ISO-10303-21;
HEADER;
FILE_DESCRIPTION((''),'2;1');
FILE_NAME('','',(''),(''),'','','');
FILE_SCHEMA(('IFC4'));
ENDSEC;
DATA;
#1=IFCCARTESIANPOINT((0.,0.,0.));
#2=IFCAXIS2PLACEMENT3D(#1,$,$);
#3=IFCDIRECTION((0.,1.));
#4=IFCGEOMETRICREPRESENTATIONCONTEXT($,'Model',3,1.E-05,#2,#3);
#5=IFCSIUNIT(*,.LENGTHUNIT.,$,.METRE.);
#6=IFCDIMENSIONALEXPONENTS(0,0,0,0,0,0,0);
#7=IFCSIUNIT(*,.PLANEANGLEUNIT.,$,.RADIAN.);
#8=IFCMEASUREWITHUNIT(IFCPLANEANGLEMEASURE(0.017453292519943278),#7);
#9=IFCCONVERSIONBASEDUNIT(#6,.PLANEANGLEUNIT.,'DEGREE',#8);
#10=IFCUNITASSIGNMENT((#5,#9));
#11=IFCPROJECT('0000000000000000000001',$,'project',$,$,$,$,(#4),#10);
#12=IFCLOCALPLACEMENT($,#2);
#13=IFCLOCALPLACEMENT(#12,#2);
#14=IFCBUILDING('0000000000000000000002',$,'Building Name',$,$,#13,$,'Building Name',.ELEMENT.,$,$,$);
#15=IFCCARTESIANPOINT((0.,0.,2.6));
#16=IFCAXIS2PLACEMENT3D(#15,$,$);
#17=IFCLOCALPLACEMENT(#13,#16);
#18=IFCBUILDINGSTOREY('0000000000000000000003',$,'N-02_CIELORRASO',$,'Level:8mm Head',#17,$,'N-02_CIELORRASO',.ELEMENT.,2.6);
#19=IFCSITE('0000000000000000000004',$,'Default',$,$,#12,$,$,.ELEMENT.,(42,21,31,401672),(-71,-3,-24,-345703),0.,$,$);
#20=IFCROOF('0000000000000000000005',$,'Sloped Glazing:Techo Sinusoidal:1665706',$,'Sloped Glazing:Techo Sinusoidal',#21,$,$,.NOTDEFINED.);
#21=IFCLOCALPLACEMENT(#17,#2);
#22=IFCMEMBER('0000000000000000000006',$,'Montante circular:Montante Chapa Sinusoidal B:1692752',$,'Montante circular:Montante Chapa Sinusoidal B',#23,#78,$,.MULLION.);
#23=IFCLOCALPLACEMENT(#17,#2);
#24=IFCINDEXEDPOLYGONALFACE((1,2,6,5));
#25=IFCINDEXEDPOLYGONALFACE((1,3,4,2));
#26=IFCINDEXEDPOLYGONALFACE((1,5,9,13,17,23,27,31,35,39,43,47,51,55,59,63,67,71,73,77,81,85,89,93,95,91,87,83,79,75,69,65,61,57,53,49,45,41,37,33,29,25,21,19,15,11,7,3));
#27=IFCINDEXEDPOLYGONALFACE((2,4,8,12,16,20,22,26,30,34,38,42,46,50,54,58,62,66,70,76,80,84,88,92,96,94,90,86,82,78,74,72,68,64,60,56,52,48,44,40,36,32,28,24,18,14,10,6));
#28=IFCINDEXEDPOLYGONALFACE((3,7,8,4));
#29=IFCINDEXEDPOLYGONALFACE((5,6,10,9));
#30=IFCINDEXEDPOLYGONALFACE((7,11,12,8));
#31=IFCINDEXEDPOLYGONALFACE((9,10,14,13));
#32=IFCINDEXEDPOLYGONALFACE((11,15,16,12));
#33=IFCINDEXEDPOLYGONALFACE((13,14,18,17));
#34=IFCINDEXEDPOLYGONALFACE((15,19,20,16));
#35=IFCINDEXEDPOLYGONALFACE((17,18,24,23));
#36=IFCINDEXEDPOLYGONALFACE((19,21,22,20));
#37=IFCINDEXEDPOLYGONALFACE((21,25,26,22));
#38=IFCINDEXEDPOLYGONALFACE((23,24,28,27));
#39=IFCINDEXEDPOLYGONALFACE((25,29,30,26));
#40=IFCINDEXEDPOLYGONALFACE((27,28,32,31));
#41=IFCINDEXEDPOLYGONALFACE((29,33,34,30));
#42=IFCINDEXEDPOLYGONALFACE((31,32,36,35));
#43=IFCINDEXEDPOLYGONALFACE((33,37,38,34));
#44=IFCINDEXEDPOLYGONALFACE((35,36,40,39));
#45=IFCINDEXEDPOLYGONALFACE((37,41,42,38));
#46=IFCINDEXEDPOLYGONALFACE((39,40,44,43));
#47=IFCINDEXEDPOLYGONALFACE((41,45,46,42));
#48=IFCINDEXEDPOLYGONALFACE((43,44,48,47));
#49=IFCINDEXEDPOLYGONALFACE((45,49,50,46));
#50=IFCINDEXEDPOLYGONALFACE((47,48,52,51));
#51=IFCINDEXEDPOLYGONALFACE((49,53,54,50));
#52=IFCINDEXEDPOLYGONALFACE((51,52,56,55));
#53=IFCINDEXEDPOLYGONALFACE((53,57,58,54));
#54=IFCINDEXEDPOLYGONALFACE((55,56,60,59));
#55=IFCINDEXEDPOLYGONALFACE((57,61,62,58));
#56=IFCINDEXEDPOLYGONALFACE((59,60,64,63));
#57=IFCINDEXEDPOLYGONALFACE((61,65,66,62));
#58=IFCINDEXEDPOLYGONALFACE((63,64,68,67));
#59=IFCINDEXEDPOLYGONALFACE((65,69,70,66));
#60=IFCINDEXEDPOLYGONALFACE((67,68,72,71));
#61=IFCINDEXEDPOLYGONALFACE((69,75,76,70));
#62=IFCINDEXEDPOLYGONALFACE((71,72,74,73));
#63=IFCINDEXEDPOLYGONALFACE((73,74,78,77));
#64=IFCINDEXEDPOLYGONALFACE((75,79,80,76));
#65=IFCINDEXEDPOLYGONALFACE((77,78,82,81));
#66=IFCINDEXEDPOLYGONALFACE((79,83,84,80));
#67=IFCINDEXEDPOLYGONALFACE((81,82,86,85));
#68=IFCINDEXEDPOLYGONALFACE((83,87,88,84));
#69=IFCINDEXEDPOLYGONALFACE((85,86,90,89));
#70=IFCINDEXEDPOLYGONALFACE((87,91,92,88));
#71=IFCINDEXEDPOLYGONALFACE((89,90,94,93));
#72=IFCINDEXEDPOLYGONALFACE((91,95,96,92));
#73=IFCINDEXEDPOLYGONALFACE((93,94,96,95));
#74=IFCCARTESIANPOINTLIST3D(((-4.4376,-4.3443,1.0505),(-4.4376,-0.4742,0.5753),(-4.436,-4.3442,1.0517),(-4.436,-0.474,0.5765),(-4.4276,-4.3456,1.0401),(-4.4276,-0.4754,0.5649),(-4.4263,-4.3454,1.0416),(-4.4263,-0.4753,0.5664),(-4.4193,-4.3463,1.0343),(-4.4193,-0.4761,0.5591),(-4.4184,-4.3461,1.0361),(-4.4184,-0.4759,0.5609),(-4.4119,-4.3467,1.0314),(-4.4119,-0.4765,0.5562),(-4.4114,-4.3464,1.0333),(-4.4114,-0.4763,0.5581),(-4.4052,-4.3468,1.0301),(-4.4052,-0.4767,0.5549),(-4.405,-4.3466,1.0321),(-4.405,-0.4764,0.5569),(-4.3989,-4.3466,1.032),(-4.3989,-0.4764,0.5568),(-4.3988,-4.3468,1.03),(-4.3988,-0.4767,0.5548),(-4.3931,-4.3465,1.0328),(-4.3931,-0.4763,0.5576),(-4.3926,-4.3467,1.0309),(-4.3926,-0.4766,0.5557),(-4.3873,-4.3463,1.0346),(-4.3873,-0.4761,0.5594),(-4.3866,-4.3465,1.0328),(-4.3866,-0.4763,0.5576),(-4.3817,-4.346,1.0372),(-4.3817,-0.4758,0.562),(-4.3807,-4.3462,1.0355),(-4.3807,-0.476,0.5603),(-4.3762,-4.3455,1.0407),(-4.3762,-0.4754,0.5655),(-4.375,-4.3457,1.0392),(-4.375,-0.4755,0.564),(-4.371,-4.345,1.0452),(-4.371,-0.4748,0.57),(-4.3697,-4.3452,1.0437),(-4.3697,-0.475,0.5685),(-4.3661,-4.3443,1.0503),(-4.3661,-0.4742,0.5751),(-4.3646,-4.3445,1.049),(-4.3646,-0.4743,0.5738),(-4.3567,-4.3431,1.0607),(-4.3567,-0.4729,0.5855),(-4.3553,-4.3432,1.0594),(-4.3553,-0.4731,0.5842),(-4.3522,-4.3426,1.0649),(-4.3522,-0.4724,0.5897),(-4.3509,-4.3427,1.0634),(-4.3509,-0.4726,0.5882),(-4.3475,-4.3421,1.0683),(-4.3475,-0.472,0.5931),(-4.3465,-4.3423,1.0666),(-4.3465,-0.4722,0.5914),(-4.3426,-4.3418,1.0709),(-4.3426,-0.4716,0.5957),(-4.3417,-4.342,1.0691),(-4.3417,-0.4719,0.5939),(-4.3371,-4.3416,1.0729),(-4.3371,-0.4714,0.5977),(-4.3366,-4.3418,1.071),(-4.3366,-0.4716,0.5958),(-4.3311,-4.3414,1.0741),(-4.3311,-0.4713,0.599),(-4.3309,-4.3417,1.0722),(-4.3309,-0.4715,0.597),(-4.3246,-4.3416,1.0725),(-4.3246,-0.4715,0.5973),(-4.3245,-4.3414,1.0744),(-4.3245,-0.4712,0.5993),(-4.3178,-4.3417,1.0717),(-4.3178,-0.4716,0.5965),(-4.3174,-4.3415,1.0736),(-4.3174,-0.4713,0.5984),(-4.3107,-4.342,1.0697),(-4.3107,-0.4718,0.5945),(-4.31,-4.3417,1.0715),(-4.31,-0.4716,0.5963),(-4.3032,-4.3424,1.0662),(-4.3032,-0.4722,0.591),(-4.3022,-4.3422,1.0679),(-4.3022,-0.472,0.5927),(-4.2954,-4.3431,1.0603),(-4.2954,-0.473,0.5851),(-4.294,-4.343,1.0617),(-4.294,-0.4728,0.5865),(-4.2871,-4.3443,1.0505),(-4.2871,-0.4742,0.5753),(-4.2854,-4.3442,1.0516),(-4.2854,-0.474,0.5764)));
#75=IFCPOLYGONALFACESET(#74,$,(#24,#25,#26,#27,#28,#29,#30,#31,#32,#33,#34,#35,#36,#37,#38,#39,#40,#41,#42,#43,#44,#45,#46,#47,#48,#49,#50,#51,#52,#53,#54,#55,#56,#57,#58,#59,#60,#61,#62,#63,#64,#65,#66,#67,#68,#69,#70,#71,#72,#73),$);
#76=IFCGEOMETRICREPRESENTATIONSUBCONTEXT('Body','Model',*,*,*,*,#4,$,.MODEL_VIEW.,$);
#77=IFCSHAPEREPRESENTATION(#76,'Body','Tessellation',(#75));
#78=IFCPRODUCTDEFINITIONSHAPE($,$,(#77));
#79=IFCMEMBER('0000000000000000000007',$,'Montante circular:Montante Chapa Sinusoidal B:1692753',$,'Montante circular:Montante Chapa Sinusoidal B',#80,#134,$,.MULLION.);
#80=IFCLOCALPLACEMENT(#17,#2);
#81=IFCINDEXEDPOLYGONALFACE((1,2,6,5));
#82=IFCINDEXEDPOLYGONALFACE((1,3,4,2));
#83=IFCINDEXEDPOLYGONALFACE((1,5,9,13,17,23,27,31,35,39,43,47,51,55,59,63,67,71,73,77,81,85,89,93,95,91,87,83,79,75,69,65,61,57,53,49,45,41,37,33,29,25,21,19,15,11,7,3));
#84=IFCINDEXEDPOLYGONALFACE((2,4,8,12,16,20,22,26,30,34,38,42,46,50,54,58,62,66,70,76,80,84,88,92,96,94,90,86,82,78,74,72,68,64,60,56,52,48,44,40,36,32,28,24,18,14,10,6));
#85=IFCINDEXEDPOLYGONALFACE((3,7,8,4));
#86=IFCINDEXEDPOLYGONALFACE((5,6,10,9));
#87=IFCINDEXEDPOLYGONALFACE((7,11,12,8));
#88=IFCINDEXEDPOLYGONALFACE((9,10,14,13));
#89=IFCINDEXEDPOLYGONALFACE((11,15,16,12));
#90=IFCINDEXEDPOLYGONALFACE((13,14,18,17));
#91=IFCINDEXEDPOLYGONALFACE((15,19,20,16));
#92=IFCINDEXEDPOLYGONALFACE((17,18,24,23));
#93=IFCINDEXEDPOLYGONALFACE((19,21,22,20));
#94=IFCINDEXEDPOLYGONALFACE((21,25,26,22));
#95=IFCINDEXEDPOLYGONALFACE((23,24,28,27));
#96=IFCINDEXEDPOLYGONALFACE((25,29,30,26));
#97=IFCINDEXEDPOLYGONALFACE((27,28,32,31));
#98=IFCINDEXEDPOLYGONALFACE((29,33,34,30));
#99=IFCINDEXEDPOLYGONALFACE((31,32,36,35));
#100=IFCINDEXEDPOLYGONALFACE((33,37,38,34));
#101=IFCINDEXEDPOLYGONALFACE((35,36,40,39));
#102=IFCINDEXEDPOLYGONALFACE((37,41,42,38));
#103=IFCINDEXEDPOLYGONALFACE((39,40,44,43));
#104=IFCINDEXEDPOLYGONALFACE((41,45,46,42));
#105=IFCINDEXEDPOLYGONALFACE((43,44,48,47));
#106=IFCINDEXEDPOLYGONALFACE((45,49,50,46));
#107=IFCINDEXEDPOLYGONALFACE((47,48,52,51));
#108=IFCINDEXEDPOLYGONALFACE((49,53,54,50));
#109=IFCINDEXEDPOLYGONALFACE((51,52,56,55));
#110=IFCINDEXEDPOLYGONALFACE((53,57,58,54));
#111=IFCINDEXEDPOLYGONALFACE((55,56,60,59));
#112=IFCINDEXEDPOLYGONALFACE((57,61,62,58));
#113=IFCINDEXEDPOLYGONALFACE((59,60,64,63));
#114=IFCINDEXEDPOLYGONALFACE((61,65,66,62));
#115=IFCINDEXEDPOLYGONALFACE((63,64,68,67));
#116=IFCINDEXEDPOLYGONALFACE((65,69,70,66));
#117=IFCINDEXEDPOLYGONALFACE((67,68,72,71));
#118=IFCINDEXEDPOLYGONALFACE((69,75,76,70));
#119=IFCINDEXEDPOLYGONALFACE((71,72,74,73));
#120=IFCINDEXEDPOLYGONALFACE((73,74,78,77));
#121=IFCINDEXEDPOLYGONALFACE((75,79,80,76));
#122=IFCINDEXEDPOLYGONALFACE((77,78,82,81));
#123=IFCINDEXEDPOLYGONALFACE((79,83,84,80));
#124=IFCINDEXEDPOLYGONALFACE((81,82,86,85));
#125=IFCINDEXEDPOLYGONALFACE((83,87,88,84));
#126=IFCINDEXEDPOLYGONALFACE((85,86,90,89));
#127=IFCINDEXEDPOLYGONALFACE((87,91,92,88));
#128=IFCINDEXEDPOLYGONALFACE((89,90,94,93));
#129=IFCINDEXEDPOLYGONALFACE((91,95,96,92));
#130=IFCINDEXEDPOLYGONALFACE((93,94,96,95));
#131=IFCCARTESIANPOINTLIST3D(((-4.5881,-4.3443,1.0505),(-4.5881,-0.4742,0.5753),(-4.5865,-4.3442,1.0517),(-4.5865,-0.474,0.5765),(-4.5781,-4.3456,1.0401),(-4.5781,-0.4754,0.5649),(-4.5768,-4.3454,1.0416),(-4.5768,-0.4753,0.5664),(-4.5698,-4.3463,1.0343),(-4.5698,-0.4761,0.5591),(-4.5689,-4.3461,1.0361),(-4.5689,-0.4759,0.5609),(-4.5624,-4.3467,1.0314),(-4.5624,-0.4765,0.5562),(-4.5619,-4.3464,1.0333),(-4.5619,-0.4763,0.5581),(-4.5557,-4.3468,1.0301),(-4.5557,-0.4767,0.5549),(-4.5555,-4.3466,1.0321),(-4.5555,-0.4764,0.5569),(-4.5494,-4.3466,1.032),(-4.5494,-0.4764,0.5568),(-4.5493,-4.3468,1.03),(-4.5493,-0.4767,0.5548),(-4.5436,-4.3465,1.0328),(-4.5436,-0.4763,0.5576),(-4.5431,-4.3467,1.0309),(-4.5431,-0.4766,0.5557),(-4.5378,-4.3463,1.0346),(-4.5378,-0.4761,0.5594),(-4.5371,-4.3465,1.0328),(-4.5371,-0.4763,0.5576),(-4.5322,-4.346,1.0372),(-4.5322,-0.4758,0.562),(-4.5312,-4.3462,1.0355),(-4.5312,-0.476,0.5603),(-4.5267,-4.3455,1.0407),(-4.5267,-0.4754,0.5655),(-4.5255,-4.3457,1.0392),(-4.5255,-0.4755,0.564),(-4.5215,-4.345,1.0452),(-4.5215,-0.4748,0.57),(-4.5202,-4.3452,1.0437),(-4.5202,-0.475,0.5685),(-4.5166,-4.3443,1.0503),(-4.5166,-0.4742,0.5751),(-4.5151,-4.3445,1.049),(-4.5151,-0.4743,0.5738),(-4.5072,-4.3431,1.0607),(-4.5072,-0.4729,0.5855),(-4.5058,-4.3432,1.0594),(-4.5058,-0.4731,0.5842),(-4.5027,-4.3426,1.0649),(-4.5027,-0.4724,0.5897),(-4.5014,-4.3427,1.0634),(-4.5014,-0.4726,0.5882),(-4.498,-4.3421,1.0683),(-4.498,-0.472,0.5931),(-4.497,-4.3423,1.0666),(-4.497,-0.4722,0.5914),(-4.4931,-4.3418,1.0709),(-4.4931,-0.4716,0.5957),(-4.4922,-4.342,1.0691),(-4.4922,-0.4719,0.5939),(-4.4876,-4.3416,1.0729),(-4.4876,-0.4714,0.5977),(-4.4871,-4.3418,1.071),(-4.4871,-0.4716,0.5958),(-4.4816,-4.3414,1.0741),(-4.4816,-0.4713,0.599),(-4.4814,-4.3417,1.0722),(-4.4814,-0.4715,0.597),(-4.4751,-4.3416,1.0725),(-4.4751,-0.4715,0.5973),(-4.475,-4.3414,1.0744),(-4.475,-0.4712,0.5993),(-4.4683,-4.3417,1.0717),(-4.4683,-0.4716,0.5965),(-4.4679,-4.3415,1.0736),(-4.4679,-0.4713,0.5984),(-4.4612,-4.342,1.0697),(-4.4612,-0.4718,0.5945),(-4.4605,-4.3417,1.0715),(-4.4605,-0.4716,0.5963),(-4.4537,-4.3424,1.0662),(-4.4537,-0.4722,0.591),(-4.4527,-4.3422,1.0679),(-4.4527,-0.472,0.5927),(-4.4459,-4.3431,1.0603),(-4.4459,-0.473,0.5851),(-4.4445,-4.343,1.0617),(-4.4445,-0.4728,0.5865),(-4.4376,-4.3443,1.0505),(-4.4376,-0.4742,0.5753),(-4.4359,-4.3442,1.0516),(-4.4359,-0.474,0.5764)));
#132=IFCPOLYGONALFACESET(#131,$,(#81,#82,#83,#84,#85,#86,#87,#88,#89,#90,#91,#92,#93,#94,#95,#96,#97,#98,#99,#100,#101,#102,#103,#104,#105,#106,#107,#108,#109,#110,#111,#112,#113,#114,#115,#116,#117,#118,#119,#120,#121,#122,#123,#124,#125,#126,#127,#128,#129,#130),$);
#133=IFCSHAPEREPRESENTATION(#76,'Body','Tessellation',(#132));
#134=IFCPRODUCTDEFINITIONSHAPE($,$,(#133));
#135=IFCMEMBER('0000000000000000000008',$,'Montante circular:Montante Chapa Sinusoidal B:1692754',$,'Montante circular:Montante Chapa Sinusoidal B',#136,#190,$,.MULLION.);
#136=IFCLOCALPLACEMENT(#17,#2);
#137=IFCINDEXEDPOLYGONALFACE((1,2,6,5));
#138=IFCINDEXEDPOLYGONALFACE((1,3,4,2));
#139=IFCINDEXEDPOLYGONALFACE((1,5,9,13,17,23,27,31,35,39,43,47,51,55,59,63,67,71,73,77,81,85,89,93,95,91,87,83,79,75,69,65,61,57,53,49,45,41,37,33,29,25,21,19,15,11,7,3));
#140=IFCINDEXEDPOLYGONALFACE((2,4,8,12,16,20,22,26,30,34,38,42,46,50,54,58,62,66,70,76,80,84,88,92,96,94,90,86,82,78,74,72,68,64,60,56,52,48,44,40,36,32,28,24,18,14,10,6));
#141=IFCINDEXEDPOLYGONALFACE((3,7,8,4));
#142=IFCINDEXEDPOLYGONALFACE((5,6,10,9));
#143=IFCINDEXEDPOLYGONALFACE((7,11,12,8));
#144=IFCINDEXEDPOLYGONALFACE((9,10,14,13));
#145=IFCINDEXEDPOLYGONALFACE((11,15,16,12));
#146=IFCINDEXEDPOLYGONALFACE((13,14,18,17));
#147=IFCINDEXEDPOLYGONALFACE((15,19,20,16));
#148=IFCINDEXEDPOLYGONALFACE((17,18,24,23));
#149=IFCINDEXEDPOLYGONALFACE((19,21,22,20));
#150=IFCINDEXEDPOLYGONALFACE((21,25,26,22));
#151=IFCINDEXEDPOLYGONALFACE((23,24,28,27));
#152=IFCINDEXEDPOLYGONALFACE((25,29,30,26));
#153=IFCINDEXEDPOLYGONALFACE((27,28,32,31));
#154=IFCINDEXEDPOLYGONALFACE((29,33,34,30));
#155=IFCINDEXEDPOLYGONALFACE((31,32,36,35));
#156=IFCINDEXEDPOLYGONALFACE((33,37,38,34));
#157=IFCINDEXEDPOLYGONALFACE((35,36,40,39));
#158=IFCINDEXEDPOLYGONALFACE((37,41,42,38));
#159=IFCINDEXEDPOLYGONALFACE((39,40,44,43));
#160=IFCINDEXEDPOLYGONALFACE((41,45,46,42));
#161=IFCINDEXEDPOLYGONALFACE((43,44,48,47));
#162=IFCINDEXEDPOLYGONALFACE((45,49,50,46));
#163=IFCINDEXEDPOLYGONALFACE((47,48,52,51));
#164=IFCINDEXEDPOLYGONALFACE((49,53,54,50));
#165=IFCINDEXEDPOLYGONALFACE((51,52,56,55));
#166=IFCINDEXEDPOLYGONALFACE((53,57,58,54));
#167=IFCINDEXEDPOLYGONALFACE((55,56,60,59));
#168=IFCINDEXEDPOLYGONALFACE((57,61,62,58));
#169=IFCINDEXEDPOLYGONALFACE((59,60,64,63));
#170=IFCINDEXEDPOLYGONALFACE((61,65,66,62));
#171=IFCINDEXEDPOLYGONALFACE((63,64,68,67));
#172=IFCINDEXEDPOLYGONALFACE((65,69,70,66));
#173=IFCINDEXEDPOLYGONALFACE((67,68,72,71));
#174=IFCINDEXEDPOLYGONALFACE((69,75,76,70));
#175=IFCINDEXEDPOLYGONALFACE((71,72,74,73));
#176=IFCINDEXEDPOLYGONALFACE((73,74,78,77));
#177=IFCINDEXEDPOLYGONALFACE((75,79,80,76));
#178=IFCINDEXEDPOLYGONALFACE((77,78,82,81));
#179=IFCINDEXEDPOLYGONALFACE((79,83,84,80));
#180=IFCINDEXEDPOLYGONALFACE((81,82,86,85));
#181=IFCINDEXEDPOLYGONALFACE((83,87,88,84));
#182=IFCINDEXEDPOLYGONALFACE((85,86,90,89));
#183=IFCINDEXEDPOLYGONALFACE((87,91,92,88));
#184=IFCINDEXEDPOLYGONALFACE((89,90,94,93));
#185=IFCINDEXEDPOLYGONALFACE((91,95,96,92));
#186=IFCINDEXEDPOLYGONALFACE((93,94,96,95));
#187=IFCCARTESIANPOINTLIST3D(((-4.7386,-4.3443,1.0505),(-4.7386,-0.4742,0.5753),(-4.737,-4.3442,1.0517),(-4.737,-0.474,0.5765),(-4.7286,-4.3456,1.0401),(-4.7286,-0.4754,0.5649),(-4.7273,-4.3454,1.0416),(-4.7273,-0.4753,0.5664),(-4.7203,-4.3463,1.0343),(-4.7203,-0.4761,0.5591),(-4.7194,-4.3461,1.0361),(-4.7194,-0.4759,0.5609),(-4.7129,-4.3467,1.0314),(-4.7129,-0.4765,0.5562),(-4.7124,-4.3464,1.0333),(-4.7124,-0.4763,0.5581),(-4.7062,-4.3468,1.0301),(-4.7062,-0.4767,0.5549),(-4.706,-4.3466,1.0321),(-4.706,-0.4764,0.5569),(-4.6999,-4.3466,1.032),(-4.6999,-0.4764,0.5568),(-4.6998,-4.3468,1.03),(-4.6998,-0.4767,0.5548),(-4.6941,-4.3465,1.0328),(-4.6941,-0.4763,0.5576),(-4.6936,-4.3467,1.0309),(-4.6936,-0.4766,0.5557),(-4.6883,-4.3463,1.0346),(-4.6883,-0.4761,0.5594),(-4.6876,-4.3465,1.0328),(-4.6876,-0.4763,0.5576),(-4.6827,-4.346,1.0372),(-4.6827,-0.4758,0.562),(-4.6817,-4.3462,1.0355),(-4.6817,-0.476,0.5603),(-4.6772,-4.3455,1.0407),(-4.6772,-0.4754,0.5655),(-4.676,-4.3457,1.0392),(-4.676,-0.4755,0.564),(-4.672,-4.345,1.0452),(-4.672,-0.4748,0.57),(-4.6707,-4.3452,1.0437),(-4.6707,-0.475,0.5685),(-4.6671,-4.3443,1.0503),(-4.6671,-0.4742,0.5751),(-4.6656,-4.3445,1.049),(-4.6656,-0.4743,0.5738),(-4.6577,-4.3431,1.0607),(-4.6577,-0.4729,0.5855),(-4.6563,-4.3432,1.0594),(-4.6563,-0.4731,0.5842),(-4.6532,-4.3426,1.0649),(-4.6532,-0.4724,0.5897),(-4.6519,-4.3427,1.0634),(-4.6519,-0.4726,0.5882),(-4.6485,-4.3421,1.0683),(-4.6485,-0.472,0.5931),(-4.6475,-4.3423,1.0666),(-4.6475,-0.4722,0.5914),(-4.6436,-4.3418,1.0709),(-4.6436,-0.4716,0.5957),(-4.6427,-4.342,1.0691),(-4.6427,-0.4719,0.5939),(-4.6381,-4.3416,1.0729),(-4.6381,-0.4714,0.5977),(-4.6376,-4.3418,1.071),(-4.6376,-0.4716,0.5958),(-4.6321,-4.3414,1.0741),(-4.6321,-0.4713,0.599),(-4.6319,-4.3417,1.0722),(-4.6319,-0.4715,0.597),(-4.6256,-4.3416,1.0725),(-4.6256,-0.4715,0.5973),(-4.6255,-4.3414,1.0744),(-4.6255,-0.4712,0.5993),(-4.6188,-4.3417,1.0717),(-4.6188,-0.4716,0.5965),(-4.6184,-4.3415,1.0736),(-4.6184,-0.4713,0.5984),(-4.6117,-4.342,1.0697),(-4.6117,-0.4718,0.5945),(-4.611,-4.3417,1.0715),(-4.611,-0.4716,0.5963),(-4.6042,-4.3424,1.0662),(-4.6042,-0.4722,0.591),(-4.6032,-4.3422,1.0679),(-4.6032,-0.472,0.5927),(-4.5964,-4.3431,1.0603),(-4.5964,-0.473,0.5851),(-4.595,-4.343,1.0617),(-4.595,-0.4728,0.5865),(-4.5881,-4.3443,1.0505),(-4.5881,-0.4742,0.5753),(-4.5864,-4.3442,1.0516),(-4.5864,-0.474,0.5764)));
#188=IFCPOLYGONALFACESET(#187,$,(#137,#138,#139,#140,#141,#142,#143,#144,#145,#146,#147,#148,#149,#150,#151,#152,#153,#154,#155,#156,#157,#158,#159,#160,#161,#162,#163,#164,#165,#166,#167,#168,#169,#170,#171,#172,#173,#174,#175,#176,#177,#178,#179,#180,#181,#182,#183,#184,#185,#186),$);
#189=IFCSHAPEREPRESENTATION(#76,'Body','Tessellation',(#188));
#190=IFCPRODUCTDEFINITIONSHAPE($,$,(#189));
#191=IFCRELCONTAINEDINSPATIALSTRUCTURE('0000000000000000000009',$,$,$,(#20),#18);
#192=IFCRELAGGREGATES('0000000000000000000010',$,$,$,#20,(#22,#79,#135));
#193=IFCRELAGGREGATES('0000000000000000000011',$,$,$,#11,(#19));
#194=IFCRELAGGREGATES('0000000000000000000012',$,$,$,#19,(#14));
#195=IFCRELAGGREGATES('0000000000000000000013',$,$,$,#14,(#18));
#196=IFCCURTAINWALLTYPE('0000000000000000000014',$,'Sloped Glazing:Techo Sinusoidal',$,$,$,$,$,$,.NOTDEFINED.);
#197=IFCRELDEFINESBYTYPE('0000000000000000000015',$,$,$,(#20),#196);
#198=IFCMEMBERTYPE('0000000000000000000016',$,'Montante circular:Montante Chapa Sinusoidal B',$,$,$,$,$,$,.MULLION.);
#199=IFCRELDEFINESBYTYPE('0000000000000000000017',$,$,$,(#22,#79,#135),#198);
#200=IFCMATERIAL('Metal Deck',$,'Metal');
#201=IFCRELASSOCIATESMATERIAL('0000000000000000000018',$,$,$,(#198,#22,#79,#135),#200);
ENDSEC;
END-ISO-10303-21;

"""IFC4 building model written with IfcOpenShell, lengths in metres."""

from ifc_helpers import new_model, entity, si_unit, converted_unit, direction, frame, origin, place, context, subcontext, project, spatial, indexed_curve, outline, extrude, source, transform, mapped, material, type_object, type_shapes, element, aggregate, save


model = new_model("IFC4")

# Units and contexts
model_context = context("Model", 3, precision=1e-05, world=origin(), true_north=direction((0.0, 1.0)))
body_context = subcontext(model_context, "Body", "Model", "MODEL_VIEW")
ifc_project = project(units=[si_unit("LENGTHUNIT", "METRE"), converted_unit("PLANEANGLEUNIT", "DEGREE", entity("IfcPlaneAngleMeasure", 0.017453292519943278), si_unit("PLANEANGLEUNIT", "RADIAN"), dimensions=[0, 0, 0, 0, 0, 0, 0])], contexts=[model_context])

# Site, building, storey
site_placement = place(None, origin())
site = spatial("IfcSite", under=ifc_project, at=site_placement, Name="Default", CompositionType="ELEMENT", RefLatitude=(42, 21, 31, 401672), RefLongitude=(-71, -3, -24, -345703), RefElevation=0.0)
building_placement = place(site_placement, origin())
building = spatial("IfcBuilding", under=site, at=building_placement, Name="Building Name", LongName="Building Name", CompositionType="ELEMENT")
storey_placement = place(building_placement, frame((0.0, 0.0, 2.6)))
storey = spatial("IfcBuildingStorey", under=building, at=storey_placement, Name="N-02_CIELORRASO", ObjectType="Level:8mm Head", LongName="N-02_CIELORRASO", CompositionType="ELEMENT", Elevation=2.6)

# Roof, members
curtain_wall_type = type_object("IfcCurtainWallType", Name="Sloped Glazing:Techo Sinusoidal", PredefinedType="NOTDEFINED")
ifc_material = material(Name="Metal Deck", Category="Metal")
roof_1_placement = place(storey_placement, frame((0.0, 0.0, -2.6)))
roof_1 = element("IfcRoof", 1, at=roof_1_placement, inside=storey, type_object=curtain_wall_type, Name="Sloped Glazing:Techo Sinusoidal:1665706", ObjectType="Sloped Glazing:Techo Sinusoidal", PredefinedType="NOTDEFINED")
member_type_1 = type_object("IfcMemberType", Name="Montante circular:Montante Chapa Sinusoidal B", PredefinedType="MULLION", material=ifc_material)
shared_shape_1 = source(origin(), body_context, "Body", "SweptSolid", [
    extrude(outline(indexed_curve([(0.0595, -0.0443), (0.0615, -0.0443), (0.0603, -0.031), (0.0572, -0.0213), (0.053, -0.0138), (0.0481, -0.0078), (0.0427, -0.003), (0.0372, 0.0005), (0.0315, 0.0029), (0.0259, 0.0044), (0.0203, 0.0051), (0.0146, 0.005), (0.0084, 0.0041), (-0.0053, 0.0009), (-0.0123, -0.0005), (-0.0191, -0.0012), (-0.0256, -0.001), (-0.0317, 0.0001), (-0.0375, 0.0019), (-0.0428, 0.0046), (-0.0477, 0.0081), (-0.0522, 0.0128), (-0.0563, 0.0191), (-0.0597, 0.0282), (-0.0617, 0.0421), (-0.0637, 0.042), (-0.0616, 0.0277), (-0.0581, 0.0182), (-0.0537, 0.0116), (-0.049, 0.0066), (-0.0438, 0.0028), (-0.0382, 0.0001), (-0.0322, -0.0019), (-0.0258, -0.003), (-0.019, -0.0032), (-0.012, -0.0025), (-0.0048, -0.0011), (0.0088, 0.0021), (0.0147, 0.003), (0.0202, 0.0031), (0.0255, 0.0024), (0.0309, 0.001), (0.0362, -0.0013), (0.0415, -0.0046), (0.0466, -0.0092), (0.0513, -0.0149), (0.0554, -0.0221), (0.0584, -0.0314), (0.0595, -0.0443)], self_intersect=False)), frame((-0.007, 0.0228, -3.8992), z_axis=(0.0, 0.0, 1.0), x_axis=(-0.819152, -0.573576, 0.0)), (0.0, 0.0, 1.0), 3.8992),
])
type_shapes(member_type_1, [shared_shape_1])
member_1_placement = place(roof_1_placement, frame((-4.3683, -4.3413, 3.6752), z_axis=(0.0, -0.992546, 0.121869), x_axis=(-1.0, 0.0, 0.0)))
member_1 = element("IfcMember", 2, at=member_1_placement, type_object=member_type_1, material=ifc_material, Name="Montante circular:Montante Chapa Sinusoidal B:1692752", ObjectType="Montante circular:Montante Chapa Sinusoidal B", PredefinedType="MULLION", context=body_context, shape_type="MappedRepresentation", body=[
    mapped(shared_shape_1, transform((0.0, 0.0, 0.0), scale=1.0)),
])
member_2_placement = place(roof_1_placement, frame((-4.5188, -4.3413, 3.6752), z_axis=(0.0, -0.992546, 0.121869), x_axis=(-1.0, 0.0, 0.0)))
member_2 = element("IfcMember", 3, at=member_2_placement, type_object=member_type_1, material=ifc_material, Name="Montante circular:Montante Chapa Sinusoidal B:1692753", ObjectType="Montante circular:Montante Chapa Sinusoidal B", PredefinedType="MULLION", context=body_context, shape_type="MappedRepresentation", body=[
    mapped(shared_shape_1, transform((0.0, 0.0, 0.0), scale=1.0)),
])
member_3_placement = place(roof_1_placement, frame((-4.6693, -4.3413, 3.6752), z_axis=(0.0, -0.992546, 0.121869), x_axis=(-1.0, 0.0, 0.0)))
member_3 = element("IfcMember", 4, at=member_3_placement, type_object=member_type_1, material=ifc_material, Name="Montante circular:Montante Chapa Sinusoidal B:1692754", ObjectType="Montante circular:Montante Chapa Sinusoidal B", PredefinedType="MULLION", context=body_context, shape_type="MappedRepresentation", body=[
    mapped(shared_shape_1, transform((0.0, 0.0, 0.0), scale=1.0)),
])
aggregate(roof_1, [member_1, member_2, member_3])

save(model, "model.ifc")
